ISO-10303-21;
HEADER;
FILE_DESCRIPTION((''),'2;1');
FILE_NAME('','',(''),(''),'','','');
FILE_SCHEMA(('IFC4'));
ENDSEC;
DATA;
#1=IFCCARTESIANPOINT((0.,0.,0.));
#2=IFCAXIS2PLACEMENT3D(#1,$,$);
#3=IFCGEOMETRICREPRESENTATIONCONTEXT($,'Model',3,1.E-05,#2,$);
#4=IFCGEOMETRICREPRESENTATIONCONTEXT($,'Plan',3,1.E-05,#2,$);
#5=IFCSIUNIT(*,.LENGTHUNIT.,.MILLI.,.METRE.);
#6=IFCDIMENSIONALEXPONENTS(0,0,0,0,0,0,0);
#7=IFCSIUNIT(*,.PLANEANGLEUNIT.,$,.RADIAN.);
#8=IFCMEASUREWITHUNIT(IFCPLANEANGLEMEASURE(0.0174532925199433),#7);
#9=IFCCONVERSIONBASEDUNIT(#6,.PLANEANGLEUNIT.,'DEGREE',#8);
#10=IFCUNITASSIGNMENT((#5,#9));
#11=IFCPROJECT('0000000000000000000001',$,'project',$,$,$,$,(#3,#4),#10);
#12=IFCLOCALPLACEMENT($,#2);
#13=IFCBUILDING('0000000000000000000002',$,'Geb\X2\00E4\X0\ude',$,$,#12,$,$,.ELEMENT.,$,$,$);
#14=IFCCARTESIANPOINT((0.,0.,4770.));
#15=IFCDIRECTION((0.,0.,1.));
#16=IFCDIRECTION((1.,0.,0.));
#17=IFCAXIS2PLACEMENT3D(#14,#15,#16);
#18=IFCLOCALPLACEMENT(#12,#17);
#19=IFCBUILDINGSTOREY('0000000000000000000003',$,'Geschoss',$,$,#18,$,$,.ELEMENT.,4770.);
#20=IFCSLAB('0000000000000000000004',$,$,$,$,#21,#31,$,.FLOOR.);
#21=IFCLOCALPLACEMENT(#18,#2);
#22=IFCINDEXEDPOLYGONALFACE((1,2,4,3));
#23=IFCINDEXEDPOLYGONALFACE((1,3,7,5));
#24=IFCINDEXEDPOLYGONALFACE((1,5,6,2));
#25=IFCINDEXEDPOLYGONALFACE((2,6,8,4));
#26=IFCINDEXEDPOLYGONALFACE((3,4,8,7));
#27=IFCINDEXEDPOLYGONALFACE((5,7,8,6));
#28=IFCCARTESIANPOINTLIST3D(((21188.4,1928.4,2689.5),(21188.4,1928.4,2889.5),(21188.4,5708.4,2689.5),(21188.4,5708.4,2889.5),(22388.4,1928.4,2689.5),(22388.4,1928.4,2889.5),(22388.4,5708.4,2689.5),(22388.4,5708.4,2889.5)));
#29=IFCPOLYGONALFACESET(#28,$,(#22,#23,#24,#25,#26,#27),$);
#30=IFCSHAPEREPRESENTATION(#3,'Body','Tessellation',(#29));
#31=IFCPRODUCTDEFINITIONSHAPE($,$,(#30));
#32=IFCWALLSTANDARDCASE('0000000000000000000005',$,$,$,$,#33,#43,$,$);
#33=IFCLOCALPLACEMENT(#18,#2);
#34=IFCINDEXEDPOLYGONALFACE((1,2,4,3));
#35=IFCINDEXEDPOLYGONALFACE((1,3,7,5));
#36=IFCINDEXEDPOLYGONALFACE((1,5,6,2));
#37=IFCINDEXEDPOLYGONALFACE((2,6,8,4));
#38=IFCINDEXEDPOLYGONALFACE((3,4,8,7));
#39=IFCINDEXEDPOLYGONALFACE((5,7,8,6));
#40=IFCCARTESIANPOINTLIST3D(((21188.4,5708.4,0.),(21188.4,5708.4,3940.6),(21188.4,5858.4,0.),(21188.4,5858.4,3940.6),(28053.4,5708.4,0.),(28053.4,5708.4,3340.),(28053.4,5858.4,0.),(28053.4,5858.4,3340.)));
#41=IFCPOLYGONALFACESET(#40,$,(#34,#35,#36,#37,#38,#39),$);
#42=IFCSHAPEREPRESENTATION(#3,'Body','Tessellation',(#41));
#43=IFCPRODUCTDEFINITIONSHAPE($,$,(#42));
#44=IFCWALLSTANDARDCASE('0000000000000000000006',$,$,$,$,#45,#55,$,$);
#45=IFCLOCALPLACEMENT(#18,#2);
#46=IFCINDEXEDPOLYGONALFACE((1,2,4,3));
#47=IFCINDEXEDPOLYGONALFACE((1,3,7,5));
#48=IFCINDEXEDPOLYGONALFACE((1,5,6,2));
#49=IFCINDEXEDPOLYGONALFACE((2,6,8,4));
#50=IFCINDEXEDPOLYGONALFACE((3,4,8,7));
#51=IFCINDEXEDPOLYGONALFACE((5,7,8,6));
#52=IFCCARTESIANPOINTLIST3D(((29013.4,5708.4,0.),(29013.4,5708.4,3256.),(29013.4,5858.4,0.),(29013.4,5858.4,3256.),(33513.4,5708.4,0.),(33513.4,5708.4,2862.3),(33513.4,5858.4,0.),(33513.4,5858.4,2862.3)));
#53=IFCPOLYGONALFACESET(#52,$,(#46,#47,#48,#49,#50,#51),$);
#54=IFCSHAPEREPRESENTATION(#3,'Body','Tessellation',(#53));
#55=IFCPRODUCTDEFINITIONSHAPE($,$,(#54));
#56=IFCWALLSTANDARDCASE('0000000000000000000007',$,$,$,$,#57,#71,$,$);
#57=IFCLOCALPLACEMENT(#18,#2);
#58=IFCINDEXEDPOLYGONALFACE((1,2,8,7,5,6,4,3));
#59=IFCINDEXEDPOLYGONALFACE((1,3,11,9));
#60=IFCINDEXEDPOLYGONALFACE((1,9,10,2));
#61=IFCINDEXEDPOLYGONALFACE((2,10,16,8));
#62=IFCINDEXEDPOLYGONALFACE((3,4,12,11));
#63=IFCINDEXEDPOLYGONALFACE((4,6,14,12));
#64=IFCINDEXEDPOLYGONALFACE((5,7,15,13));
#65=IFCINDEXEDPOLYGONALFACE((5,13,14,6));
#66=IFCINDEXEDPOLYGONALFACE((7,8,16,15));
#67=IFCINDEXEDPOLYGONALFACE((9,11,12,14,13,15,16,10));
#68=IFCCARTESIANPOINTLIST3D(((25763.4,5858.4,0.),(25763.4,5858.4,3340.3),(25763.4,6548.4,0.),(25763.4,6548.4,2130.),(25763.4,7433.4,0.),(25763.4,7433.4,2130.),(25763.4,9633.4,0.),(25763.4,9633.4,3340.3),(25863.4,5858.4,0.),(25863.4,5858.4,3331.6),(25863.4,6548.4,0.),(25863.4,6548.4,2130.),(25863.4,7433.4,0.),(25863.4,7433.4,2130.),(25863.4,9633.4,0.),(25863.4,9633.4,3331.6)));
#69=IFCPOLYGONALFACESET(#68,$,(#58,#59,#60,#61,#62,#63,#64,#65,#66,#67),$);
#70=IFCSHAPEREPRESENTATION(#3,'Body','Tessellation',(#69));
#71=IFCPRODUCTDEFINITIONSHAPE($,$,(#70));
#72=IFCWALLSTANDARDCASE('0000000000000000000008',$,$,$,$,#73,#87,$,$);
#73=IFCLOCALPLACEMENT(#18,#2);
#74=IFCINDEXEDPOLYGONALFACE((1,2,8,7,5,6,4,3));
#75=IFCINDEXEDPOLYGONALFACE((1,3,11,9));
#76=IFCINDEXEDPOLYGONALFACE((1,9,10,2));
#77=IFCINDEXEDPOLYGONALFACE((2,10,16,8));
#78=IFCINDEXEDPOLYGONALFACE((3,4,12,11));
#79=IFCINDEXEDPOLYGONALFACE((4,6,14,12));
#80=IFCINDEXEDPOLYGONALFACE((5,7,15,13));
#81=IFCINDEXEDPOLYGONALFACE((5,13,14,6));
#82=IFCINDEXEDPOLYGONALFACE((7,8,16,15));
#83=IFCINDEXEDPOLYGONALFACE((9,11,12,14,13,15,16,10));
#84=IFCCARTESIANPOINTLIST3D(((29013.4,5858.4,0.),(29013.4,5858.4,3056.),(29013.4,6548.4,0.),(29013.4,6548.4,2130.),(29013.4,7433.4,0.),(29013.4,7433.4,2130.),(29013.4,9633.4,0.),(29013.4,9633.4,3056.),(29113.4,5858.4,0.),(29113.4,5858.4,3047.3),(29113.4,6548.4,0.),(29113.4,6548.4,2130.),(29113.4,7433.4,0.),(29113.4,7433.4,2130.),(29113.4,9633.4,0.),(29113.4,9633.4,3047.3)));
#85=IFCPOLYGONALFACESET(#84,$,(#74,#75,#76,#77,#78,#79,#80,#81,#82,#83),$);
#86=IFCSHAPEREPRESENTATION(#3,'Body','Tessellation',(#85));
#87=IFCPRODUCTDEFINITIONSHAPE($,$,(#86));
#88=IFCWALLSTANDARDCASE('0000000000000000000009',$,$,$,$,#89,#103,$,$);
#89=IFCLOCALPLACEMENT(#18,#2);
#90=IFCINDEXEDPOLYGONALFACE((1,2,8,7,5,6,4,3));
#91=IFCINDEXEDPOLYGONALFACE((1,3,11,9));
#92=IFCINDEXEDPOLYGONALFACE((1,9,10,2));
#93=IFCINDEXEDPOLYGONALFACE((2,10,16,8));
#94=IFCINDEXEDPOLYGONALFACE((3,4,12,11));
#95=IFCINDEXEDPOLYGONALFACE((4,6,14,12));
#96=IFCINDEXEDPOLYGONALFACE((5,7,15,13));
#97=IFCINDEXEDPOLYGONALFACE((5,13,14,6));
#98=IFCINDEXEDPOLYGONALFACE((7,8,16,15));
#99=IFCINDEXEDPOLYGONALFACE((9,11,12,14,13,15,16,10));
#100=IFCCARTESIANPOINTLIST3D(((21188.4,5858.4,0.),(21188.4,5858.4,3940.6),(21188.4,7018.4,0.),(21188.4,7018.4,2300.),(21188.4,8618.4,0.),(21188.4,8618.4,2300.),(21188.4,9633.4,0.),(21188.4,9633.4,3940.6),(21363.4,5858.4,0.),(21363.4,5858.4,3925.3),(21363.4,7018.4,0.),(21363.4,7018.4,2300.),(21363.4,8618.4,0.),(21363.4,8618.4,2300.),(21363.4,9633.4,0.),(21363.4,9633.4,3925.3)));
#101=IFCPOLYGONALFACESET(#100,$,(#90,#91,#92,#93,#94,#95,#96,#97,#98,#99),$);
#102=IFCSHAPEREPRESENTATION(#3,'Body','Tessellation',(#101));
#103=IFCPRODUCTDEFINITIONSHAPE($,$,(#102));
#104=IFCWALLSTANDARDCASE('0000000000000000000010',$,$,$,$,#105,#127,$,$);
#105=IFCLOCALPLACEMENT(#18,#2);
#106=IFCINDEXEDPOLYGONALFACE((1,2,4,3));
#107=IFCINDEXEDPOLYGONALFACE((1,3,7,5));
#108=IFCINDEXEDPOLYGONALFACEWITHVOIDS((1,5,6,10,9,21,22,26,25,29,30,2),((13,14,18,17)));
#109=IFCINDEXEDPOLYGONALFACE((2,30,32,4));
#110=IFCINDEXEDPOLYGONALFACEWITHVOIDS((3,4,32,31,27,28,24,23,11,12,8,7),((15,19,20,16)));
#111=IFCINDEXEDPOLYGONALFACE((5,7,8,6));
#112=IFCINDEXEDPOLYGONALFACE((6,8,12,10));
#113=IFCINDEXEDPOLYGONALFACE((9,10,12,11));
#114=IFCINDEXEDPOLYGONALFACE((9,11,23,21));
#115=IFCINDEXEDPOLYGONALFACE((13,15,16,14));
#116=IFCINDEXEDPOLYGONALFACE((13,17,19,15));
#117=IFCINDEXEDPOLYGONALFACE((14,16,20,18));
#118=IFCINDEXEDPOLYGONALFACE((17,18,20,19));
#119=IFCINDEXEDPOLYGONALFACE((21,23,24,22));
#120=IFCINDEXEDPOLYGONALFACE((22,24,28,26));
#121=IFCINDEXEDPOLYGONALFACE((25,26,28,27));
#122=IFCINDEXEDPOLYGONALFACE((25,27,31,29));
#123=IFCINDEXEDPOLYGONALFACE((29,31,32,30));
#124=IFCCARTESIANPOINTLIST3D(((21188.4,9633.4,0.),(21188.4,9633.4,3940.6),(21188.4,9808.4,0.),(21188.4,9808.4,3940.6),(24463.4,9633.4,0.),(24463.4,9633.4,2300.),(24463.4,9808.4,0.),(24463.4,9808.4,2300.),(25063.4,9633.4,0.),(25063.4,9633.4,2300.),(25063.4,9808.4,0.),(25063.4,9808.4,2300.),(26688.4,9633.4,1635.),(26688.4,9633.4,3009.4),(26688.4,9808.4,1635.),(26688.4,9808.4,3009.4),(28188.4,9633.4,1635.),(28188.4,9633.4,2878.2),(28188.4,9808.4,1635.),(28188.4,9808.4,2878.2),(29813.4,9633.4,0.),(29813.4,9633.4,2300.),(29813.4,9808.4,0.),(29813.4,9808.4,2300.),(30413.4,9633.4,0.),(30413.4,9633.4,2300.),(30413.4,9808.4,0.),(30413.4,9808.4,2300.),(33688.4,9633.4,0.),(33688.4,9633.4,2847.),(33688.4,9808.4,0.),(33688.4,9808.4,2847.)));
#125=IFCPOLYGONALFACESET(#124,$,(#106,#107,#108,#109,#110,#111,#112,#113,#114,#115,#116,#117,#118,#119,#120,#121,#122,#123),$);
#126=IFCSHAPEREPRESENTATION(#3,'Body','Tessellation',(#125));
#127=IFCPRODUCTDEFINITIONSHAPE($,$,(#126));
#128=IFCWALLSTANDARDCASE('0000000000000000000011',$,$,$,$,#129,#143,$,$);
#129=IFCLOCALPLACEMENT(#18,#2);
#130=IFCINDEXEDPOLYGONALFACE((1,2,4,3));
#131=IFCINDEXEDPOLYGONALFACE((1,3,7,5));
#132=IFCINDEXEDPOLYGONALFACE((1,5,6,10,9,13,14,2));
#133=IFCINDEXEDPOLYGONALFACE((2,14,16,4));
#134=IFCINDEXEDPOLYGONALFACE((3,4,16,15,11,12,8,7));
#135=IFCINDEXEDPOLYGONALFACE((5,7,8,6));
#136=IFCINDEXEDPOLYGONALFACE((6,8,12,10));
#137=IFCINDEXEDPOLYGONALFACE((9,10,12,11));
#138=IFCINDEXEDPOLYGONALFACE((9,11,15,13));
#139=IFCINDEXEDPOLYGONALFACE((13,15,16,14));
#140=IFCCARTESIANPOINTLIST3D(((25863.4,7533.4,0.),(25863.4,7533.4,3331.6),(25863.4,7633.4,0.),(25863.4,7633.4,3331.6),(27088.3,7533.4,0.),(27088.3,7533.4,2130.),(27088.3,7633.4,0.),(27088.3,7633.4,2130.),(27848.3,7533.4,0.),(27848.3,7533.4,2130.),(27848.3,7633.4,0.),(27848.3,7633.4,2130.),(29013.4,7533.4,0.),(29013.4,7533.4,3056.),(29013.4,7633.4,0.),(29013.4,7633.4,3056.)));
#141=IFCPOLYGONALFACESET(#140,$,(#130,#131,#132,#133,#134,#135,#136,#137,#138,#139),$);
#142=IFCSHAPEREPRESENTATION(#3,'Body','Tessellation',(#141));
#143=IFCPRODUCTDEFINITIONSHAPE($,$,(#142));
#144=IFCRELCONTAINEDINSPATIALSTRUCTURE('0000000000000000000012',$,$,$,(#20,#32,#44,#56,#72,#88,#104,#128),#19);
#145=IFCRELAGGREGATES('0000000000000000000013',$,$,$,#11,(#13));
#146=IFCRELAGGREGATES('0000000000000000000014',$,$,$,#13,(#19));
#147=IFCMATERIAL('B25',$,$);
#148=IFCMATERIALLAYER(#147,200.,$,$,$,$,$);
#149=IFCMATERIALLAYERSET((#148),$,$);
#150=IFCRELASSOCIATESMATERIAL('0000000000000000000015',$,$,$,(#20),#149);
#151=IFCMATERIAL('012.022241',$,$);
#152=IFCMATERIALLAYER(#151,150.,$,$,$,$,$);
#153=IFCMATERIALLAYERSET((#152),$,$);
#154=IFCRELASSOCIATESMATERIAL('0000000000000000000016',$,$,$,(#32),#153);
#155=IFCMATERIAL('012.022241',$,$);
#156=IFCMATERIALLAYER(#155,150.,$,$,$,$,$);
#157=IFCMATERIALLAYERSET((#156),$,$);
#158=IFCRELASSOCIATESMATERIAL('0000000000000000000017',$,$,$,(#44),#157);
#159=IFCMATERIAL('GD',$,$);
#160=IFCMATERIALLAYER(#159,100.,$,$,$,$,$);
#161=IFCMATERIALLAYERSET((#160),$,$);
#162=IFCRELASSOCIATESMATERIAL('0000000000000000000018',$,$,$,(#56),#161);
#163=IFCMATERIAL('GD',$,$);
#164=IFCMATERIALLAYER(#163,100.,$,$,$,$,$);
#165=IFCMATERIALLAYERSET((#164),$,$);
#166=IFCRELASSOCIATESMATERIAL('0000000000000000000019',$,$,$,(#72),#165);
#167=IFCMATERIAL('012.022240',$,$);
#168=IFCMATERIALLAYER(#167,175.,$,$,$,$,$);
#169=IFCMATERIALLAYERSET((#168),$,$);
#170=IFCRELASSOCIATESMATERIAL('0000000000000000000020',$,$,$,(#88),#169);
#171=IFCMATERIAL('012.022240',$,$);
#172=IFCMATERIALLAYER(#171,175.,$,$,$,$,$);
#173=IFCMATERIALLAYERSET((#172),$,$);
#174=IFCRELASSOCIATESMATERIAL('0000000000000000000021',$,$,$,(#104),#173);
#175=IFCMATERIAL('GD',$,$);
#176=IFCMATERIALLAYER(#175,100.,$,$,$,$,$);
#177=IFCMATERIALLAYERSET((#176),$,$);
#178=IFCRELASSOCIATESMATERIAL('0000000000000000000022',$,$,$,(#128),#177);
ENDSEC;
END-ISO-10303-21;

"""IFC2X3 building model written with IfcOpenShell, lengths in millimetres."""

from ifc_helpers import new_model, entity, si_unit, converted_unit, frame, frame_2d, origin, origin_with_axes, place, context, project, spatial, polyline, rectangle, outline, extrude, clip, halfspace, material, layer, layer_set, layer_usage, element, save


model = new_model("IFC2X3")

# Units and contexts
model_context = context("Model", 3, precision=1e-05, world=origin())
plan_context = context("Plan", 3, precision=1e-05, world=origin())
ifc_project = project(units=[si_unit("LENGTHUNIT", "METRE", prefix="MILLI"), converted_unit("PLANEANGLEUNIT", "DEGREE", entity("IfcPlaneAngleMeasure", 0.0174532925199433), si_unit("PLANEANGLEUNIT", "RADIAN"), dimensions=[0, 0, 0, 0, 0, 0, 0])], contexts=[model_context, plan_context])

# Building, storey
building_placement = place(None, origin())
building = spatial("IfcBuilding", under=ifc_project, at=building_placement, Name="Gebäude", CompositionType="ELEMENT")
storey_placement = place(building_placement, frame((0.0, 0.0, 4770.0), z_axis=(0.0, 0.0, 1.0), x_axis=(1.0, 0.0, 0.0)))
storey = spatial("IfcBuildingStorey", under=building, at=storey_placement, Name="Geschoss", CompositionType="ELEMENT", Elevation=4770.0)

# Slab
ifc_material_1 = material(Name="B25")
ifc_layer_1 = layer(ifc_material_1, 200.0)
ifc_layer_set_1 = layer_set([ifc_layer_1])
ifc_layer_usage_1 = layer_usage(ifc_layer_set_1, "AXIS3", "POSITIVE", 0.0)
slab_placement = place(storey_placement, frame((22388.4, 1928.4, 2689.5), z_axis=(0.0, 0.0, 1.0), x_axis=(1.0, 0.0, 0.0)))
element("IfcSlab", 1, at=slab_placement, inside=storey, material=ifc_layer_usage_1, PredefinedType="FLOOR", context=model_context, shape_type="SweptSolid", body=[
    extrude(rectangle(XDim=3780.0, YDim=1200.0, at=frame_2d((-600.0, 1890.0), x_axis=(0.0, 1.0))), origin_with_axes(), (0.0, 0.0, 1.0), 200.0),
])

# Walls
ifc_material_2 = material(Name="012.022241")
ifc_layer_2 = layer(ifc_material_2, 150.0)
ifc_layer_set_2 = layer_set([ifc_layer_2])
ifc_layer_usage_2 = layer_usage(ifc_layer_set_2, "AXIS2", "POSITIVE", 0.0)
wall_1_placement = place(storey_placement, frame((21188.4, 5708.4, 0.0), z_axis=(0.0, 0.0, 1.0), x_axis=(1.0, 0.0, 0.0)))
element("IfcWallStandardCase", 2, at=wall_1_placement, inside=storey, material=ifc_layer_usage_2, context=model_context, shape_type="Clipping", body=[
    clip(extrude(rectangle(XDim=6865.0, YDim=150.0, at=frame_2d((3432.5, 75.0), x_axis=(1.0, 0.0))), origin_with_axes(), (0.0, 0.0, 1.0), 3940.6), halfspace(frame((6865.0, 150.0, 3340.0), z_axis=(-0.087156, 0.0, -0.996195), x_axis=(1.0, 0.0, 0.0)), True)),
])
ifc_material_3 = material(Name="012.022241")
ifc_layer_3 = layer(ifc_material_3, 150.0)
ifc_layer_set_3 = layer_set([ifc_layer_3])
ifc_layer_usage_3 = layer_usage(ifc_layer_set_3, "AXIS2", "POSITIVE", 0.0)
wall_2_placement = place(storey_placement, frame((29013.4, 5708.4, 0.0), z_axis=(0.0, 0.0, 1.0), x_axis=(1.0, 0.0, 0.0)))
element("IfcWallStandardCase", 3, at=wall_2_placement, inside=storey, material=ifc_layer_usage_3, context=model_context, shape_type="Clipping", body=[
    clip(extrude(rectangle(XDim=4500.0, YDim=150.0, at=frame_2d((2250.0, 75.0), x_axis=(1.0, 0.0))), origin_with_axes(), (0.0, 0.0, 1.0), 3256.0), halfspace(frame((0.0, 0.0, 3256.0), z_axis=(-0.087156, 0.0, -0.996195), x_axis=(1.0, 0.0, 0.0)), True)),
])

# Walls, openings
ifc_material_4 = material(Name="GD")
ifc_layer_4 = layer(ifc_material_4, 100.0)
ifc_layer_set_4 = layer_set([ifc_layer_4])
ifc_layer_usage_4 = layer_usage(ifc_layer_set_4, "AXIS2", "POSITIVE", 0.0)
wall_3_placement = place(storey_placement, frame((25763.4, 9633.4, 0.0), z_axis=(0.0, 0.0, 1.0), x_axis=(0.0, -1.0, 0.0)))
wall_3 = element("IfcWallStandardCase", 4, at=wall_3_placement, inside=storey, material=ifc_layer_usage_4, context=model_context, shape_type="Clipping", body=[
    clip(extrude(rectangle(XDim=3775.0, YDim=100.0, at=frame_2d((1887.5, 50.0), x_axis=(1.0, 0.0))), origin_with_axes(), (0.0, 0.0, 1.0), 3340.3), halfspace(frame((0.0, 0.0, 3340.3), z_axis=(0.0, -0.087156, -0.996195), x_axis=(1.0, 0.0, 0.0)), True)),
])
opening_1_placement = place(wall_3_placement, frame((2200.0, 0.0, 0.0), z_axis=(0.0, 1.0, 0.0), x_axis=(0.0, 0.0, 1.0)))
element("IfcOpeningElement", 5, at=opening_1_placement, cuts=wall_3, ObjectType="Opening", context=model_context, shape_type="SweptSolid", body=[
    extrude(rectangle(XDim=2130.0, YDim=885.0, at=frame_2d((1065.0, 442.5), x_axis=(1.0, 0.0))), origin_with_axes(), (0.0, 0.0, 1.0), 100.0),
])
ifc_material_5 = material(Name="GD")
ifc_layer_5 = layer(ifc_material_5, 100.0)
ifc_layer_set_5 = layer_set([ifc_layer_5])
ifc_layer_usage_5 = layer_usage(ifc_layer_set_5, "AXIS2", "POSITIVE", 0.0)
wall_4_placement = place(storey_placement, frame((29113.4, 5858.4, 0.0), z_axis=(0.0, 0.0, 1.0), x_axis=(0.0, 1.0, 0.0)))
wall_4 = element("IfcWallStandardCase", 6, at=wall_4_placement, inside=storey, material=ifc_layer_usage_5, context=model_context, shape_type="Clipping", body=[
    clip(extrude(rectangle(XDim=3775.0, YDim=100.0, at=frame_2d((1887.5, 50.0), x_axis=(1.0, 0.0))), origin_with_axes(), (0.0, 0.0, 1.0), 3056.0), halfspace(frame((0.0, 0.0, 3047.3), z_axis=(0.0, 0.087156, -0.996195), x_axis=(1.0, 0.0, 0.0)), True)),
])
opening_2_placement = place(wall_4_placement, frame((690.0, 0.0, 0.0), z_axis=(0.0, 1.0, 0.0), x_axis=(0.0, 0.0, 1.0)))
element("IfcOpeningElement", 7, at=opening_2_placement, cuts=wall_4, ObjectType="Opening", context=model_context, shape_type="SweptSolid", body=[
    extrude(rectangle(XDim=2130.0, YDim=885.0, at=frame_2d((1065.0, 442.5), x_axis=(1.0, 0.0))), origin_with_axes(), (0.0, 0.0, 1.0), 100.0),
])
ifc_material_6 = material(Name="012.022240")
ifc_layer_6 = layer(ifc_material_6, 175.0)
ifc_layer_set_6 = layer_set([ifc_layer_6])
ifc_layer_usage_6 = layer_usage(ifc_layer_set_6, "AXIS2", "POSITIVE", 0.0)
wall_5_placement = place(storey_placement, frame((21188.4, 9633.4, 0.0), z_axis=(0.0, 0.0, 1.0), x_axis=(0.0, -1.0, 0.0)))
wall_5 = element("IfcWallStandardCase", 8, at=wall_5_placement, inside=storey, material=ifc_layer_usage_6, context=model_context, shape_type="Clipping", body=[
    clip(extrude(rectangle(XDim=3775.0, YDim=175.0, at=frame_2d((1887.5, 87.5), x_axis=(1.0, 0.0))), origin_with_axes(), (0.0, 0.0, 1.0), 3940.6), halfspace(frame((0.0, 175.0, 3925.3), z_axis=(0.0, -0.087156, -0.996195), x_axis=(1.0, 0.0, 0.0)), True)),
])
opening_3_placement = place(wall_5_placement, frame((1015.0, 0.0, 0.0), z_axis=(0.0, 1.0, 0.0), x_axis=(0.0, 0.0, 1.0)))
element("IfcOpeningElement", 9, at=opening_3_placement, cuts=wall_5, ObjectType="Opening", context=model_context, shape_type="SweptSolid", body=[
    extrude(rectangle(XDim=2300.0, YDim=1600.0, at=frame_2d((1150.0, 800.0), x_axis=(1.0, 0.0))), origin_with_axes(), (0.0, 0.0, 1.0), 175.0),
])

# Wall, openings
ifc_material_7 = material(Name="012.022240")
ifc_layer_7 = layer(ifc_material_7, 175.0)
ifc_layer_set_7 = layer_set([ifc_layer_7])
ifc_layer_usage_7 = layer_usage(ifc_layer_set_7, "AXIS2", "POSITIVE", 0.0)
wall_6_placement = place(storey_placement, frame((33688.4, 9808.4, 0.0), z_axis=(0.0, 0.0, 1.0), x_axis=(-1.0, 0.0, 0.0)))
wall_6 = element("IfcWallStandardCase", 10, at=wall_6_placement, inside=storey, material=ifc_layer_usage_7, context=model_context, shape_type="Clipping", body=[
    clip(extrude(rectangle(XDim=12500.0, YDim=175.0, at=frame_2d((6250.0, 87.5), x_axis=(1.0, 0.0))), origin_with_axes(), (0.0, 0.0, 1.0), 3940.6), halfspace(frame((0.0, 175.0, 2847.0), z_axis=(0.087156, 0.0, -0.996195), x_axis=(1.0, 0.0, 0.0)), True)),
])
opening_4_placement = place(wall_6_placement, frame((5500.0, 0.0, 1635.0), z_axis=(0.0, 1.0, 0.0), x_axis=(0.0, 0.0, 1.0)))
element("IfcOpeningElement", 11, at=opening_4_placement, cuts=wall_6, ObjectType="Opening", context=model_context, shape_type="SweptSolid", body=[
    extrude(outline(polyline([(0.0, 0.0), (1243.2, 0.0), (1374.4, 1500.0), (0.0, 1500.0), (0.0, 0.0)])), origin_with_axes(), (0.0, 0.0, 1.0), 175.0),
])
opening_5_placement = place(wall_6_placement, frame((3275.0, 0.0, 0.0), z_axis=(0.0, 1.0, 0.0), x_axis=(0.0, 0.0, 1.0)))
element("IfcOpeningElement", 12, at=opening_5_placement, cuts=wall_6, ObjectType="Opening", context=model_context, shape_type="SweptSolid", body=[
    extrude(rectangle(XDim=2300.0, YDim=600.0, at=frame_2d((1150.0, 300.0), x_axis=(1.0, 0.0))), origin_with_axes(), (0.0, 0.0, 1.0), 175.0),
])
opening_6_placement = place(wall_6_placement, frame((8625.0, 0.0, 0.0), z_axis=(0.0, 1.0, 0.0), x_axis=(0.0, 0.0, 1.0)))
element("IfcOpeningElement", 13, at=opening_6_placement, cuts=wall_6, ObjectType="Opening", context=model_context, shape_type="SweptSolid", body=[
    extrude(rectangle(XDim=2300.0, YDim=600.0, at=frame_2d((1150.0, 300.0), x_axis=(1.0, 0.0))), origin_with_axes(), (0.0, 0.0, 1.0), 175.0),
])

# Wall, opening
ifc_material_8 = material(Name="GD")
ifc_layer_8 = layer(ifc_material_8, 100.0)
ifc_layer_set_8 = layer_set([ifc_layer_8])
ifc_layer_usage_8 = layer_usage(ifc_layer_set_8, "AXIS2", "POSITIVE", 0.0)
wall_7_placement = place(storey_placement, frame((25863.4, 7533.4, 0.0), z_axis=(0.0, 0.0, 1.0), x_axis=(1.0, 0.0, 0.0)))
wall_7 = element("IfcWallStandardCase", 14, at=wall_7_placement, inside=storey, material=ifc_layer_usage_8, context=model_context, shape_type="Clipping", body=[
    clip(extrude(rectangle(XDim=3150.0, YDim=100.0, at=frame_2d((1575.0, 50.0), x_axis=(1.0, 0.0))), origin_with_axes(), (0.0, 0.0, 1.0), 3331.6), halfspace(frame((0.0, 0.0, 3331.6), z_axis=(-0.087156, 0.0, -0.996195), x_axis=(1.0, 0.0, 0.0)), True)),
])
opening_7_placement = place(wall_7_placement, frame((1225.0, 0.0, 0.0), z_axis=(0.0, 1.0, 0.0), x_axis=(0.0, 0.0, 1.0)))
element("IfcOpeningElement", 15, at=opening_7_placement, cuts=wall_7, ObjectType="Opening", context=model_context, shape_type="SweptSolid", body=[
    extrude(rectangle(XDim=2130.0, YDim=760.0, at=frame_2d((1065.0, 380.0), x_axis=(1.0, 0.0))), origin_with_axes(), (0.0, 0.0, 1.0), 100.0),
])

save(model, "model.ifc")
